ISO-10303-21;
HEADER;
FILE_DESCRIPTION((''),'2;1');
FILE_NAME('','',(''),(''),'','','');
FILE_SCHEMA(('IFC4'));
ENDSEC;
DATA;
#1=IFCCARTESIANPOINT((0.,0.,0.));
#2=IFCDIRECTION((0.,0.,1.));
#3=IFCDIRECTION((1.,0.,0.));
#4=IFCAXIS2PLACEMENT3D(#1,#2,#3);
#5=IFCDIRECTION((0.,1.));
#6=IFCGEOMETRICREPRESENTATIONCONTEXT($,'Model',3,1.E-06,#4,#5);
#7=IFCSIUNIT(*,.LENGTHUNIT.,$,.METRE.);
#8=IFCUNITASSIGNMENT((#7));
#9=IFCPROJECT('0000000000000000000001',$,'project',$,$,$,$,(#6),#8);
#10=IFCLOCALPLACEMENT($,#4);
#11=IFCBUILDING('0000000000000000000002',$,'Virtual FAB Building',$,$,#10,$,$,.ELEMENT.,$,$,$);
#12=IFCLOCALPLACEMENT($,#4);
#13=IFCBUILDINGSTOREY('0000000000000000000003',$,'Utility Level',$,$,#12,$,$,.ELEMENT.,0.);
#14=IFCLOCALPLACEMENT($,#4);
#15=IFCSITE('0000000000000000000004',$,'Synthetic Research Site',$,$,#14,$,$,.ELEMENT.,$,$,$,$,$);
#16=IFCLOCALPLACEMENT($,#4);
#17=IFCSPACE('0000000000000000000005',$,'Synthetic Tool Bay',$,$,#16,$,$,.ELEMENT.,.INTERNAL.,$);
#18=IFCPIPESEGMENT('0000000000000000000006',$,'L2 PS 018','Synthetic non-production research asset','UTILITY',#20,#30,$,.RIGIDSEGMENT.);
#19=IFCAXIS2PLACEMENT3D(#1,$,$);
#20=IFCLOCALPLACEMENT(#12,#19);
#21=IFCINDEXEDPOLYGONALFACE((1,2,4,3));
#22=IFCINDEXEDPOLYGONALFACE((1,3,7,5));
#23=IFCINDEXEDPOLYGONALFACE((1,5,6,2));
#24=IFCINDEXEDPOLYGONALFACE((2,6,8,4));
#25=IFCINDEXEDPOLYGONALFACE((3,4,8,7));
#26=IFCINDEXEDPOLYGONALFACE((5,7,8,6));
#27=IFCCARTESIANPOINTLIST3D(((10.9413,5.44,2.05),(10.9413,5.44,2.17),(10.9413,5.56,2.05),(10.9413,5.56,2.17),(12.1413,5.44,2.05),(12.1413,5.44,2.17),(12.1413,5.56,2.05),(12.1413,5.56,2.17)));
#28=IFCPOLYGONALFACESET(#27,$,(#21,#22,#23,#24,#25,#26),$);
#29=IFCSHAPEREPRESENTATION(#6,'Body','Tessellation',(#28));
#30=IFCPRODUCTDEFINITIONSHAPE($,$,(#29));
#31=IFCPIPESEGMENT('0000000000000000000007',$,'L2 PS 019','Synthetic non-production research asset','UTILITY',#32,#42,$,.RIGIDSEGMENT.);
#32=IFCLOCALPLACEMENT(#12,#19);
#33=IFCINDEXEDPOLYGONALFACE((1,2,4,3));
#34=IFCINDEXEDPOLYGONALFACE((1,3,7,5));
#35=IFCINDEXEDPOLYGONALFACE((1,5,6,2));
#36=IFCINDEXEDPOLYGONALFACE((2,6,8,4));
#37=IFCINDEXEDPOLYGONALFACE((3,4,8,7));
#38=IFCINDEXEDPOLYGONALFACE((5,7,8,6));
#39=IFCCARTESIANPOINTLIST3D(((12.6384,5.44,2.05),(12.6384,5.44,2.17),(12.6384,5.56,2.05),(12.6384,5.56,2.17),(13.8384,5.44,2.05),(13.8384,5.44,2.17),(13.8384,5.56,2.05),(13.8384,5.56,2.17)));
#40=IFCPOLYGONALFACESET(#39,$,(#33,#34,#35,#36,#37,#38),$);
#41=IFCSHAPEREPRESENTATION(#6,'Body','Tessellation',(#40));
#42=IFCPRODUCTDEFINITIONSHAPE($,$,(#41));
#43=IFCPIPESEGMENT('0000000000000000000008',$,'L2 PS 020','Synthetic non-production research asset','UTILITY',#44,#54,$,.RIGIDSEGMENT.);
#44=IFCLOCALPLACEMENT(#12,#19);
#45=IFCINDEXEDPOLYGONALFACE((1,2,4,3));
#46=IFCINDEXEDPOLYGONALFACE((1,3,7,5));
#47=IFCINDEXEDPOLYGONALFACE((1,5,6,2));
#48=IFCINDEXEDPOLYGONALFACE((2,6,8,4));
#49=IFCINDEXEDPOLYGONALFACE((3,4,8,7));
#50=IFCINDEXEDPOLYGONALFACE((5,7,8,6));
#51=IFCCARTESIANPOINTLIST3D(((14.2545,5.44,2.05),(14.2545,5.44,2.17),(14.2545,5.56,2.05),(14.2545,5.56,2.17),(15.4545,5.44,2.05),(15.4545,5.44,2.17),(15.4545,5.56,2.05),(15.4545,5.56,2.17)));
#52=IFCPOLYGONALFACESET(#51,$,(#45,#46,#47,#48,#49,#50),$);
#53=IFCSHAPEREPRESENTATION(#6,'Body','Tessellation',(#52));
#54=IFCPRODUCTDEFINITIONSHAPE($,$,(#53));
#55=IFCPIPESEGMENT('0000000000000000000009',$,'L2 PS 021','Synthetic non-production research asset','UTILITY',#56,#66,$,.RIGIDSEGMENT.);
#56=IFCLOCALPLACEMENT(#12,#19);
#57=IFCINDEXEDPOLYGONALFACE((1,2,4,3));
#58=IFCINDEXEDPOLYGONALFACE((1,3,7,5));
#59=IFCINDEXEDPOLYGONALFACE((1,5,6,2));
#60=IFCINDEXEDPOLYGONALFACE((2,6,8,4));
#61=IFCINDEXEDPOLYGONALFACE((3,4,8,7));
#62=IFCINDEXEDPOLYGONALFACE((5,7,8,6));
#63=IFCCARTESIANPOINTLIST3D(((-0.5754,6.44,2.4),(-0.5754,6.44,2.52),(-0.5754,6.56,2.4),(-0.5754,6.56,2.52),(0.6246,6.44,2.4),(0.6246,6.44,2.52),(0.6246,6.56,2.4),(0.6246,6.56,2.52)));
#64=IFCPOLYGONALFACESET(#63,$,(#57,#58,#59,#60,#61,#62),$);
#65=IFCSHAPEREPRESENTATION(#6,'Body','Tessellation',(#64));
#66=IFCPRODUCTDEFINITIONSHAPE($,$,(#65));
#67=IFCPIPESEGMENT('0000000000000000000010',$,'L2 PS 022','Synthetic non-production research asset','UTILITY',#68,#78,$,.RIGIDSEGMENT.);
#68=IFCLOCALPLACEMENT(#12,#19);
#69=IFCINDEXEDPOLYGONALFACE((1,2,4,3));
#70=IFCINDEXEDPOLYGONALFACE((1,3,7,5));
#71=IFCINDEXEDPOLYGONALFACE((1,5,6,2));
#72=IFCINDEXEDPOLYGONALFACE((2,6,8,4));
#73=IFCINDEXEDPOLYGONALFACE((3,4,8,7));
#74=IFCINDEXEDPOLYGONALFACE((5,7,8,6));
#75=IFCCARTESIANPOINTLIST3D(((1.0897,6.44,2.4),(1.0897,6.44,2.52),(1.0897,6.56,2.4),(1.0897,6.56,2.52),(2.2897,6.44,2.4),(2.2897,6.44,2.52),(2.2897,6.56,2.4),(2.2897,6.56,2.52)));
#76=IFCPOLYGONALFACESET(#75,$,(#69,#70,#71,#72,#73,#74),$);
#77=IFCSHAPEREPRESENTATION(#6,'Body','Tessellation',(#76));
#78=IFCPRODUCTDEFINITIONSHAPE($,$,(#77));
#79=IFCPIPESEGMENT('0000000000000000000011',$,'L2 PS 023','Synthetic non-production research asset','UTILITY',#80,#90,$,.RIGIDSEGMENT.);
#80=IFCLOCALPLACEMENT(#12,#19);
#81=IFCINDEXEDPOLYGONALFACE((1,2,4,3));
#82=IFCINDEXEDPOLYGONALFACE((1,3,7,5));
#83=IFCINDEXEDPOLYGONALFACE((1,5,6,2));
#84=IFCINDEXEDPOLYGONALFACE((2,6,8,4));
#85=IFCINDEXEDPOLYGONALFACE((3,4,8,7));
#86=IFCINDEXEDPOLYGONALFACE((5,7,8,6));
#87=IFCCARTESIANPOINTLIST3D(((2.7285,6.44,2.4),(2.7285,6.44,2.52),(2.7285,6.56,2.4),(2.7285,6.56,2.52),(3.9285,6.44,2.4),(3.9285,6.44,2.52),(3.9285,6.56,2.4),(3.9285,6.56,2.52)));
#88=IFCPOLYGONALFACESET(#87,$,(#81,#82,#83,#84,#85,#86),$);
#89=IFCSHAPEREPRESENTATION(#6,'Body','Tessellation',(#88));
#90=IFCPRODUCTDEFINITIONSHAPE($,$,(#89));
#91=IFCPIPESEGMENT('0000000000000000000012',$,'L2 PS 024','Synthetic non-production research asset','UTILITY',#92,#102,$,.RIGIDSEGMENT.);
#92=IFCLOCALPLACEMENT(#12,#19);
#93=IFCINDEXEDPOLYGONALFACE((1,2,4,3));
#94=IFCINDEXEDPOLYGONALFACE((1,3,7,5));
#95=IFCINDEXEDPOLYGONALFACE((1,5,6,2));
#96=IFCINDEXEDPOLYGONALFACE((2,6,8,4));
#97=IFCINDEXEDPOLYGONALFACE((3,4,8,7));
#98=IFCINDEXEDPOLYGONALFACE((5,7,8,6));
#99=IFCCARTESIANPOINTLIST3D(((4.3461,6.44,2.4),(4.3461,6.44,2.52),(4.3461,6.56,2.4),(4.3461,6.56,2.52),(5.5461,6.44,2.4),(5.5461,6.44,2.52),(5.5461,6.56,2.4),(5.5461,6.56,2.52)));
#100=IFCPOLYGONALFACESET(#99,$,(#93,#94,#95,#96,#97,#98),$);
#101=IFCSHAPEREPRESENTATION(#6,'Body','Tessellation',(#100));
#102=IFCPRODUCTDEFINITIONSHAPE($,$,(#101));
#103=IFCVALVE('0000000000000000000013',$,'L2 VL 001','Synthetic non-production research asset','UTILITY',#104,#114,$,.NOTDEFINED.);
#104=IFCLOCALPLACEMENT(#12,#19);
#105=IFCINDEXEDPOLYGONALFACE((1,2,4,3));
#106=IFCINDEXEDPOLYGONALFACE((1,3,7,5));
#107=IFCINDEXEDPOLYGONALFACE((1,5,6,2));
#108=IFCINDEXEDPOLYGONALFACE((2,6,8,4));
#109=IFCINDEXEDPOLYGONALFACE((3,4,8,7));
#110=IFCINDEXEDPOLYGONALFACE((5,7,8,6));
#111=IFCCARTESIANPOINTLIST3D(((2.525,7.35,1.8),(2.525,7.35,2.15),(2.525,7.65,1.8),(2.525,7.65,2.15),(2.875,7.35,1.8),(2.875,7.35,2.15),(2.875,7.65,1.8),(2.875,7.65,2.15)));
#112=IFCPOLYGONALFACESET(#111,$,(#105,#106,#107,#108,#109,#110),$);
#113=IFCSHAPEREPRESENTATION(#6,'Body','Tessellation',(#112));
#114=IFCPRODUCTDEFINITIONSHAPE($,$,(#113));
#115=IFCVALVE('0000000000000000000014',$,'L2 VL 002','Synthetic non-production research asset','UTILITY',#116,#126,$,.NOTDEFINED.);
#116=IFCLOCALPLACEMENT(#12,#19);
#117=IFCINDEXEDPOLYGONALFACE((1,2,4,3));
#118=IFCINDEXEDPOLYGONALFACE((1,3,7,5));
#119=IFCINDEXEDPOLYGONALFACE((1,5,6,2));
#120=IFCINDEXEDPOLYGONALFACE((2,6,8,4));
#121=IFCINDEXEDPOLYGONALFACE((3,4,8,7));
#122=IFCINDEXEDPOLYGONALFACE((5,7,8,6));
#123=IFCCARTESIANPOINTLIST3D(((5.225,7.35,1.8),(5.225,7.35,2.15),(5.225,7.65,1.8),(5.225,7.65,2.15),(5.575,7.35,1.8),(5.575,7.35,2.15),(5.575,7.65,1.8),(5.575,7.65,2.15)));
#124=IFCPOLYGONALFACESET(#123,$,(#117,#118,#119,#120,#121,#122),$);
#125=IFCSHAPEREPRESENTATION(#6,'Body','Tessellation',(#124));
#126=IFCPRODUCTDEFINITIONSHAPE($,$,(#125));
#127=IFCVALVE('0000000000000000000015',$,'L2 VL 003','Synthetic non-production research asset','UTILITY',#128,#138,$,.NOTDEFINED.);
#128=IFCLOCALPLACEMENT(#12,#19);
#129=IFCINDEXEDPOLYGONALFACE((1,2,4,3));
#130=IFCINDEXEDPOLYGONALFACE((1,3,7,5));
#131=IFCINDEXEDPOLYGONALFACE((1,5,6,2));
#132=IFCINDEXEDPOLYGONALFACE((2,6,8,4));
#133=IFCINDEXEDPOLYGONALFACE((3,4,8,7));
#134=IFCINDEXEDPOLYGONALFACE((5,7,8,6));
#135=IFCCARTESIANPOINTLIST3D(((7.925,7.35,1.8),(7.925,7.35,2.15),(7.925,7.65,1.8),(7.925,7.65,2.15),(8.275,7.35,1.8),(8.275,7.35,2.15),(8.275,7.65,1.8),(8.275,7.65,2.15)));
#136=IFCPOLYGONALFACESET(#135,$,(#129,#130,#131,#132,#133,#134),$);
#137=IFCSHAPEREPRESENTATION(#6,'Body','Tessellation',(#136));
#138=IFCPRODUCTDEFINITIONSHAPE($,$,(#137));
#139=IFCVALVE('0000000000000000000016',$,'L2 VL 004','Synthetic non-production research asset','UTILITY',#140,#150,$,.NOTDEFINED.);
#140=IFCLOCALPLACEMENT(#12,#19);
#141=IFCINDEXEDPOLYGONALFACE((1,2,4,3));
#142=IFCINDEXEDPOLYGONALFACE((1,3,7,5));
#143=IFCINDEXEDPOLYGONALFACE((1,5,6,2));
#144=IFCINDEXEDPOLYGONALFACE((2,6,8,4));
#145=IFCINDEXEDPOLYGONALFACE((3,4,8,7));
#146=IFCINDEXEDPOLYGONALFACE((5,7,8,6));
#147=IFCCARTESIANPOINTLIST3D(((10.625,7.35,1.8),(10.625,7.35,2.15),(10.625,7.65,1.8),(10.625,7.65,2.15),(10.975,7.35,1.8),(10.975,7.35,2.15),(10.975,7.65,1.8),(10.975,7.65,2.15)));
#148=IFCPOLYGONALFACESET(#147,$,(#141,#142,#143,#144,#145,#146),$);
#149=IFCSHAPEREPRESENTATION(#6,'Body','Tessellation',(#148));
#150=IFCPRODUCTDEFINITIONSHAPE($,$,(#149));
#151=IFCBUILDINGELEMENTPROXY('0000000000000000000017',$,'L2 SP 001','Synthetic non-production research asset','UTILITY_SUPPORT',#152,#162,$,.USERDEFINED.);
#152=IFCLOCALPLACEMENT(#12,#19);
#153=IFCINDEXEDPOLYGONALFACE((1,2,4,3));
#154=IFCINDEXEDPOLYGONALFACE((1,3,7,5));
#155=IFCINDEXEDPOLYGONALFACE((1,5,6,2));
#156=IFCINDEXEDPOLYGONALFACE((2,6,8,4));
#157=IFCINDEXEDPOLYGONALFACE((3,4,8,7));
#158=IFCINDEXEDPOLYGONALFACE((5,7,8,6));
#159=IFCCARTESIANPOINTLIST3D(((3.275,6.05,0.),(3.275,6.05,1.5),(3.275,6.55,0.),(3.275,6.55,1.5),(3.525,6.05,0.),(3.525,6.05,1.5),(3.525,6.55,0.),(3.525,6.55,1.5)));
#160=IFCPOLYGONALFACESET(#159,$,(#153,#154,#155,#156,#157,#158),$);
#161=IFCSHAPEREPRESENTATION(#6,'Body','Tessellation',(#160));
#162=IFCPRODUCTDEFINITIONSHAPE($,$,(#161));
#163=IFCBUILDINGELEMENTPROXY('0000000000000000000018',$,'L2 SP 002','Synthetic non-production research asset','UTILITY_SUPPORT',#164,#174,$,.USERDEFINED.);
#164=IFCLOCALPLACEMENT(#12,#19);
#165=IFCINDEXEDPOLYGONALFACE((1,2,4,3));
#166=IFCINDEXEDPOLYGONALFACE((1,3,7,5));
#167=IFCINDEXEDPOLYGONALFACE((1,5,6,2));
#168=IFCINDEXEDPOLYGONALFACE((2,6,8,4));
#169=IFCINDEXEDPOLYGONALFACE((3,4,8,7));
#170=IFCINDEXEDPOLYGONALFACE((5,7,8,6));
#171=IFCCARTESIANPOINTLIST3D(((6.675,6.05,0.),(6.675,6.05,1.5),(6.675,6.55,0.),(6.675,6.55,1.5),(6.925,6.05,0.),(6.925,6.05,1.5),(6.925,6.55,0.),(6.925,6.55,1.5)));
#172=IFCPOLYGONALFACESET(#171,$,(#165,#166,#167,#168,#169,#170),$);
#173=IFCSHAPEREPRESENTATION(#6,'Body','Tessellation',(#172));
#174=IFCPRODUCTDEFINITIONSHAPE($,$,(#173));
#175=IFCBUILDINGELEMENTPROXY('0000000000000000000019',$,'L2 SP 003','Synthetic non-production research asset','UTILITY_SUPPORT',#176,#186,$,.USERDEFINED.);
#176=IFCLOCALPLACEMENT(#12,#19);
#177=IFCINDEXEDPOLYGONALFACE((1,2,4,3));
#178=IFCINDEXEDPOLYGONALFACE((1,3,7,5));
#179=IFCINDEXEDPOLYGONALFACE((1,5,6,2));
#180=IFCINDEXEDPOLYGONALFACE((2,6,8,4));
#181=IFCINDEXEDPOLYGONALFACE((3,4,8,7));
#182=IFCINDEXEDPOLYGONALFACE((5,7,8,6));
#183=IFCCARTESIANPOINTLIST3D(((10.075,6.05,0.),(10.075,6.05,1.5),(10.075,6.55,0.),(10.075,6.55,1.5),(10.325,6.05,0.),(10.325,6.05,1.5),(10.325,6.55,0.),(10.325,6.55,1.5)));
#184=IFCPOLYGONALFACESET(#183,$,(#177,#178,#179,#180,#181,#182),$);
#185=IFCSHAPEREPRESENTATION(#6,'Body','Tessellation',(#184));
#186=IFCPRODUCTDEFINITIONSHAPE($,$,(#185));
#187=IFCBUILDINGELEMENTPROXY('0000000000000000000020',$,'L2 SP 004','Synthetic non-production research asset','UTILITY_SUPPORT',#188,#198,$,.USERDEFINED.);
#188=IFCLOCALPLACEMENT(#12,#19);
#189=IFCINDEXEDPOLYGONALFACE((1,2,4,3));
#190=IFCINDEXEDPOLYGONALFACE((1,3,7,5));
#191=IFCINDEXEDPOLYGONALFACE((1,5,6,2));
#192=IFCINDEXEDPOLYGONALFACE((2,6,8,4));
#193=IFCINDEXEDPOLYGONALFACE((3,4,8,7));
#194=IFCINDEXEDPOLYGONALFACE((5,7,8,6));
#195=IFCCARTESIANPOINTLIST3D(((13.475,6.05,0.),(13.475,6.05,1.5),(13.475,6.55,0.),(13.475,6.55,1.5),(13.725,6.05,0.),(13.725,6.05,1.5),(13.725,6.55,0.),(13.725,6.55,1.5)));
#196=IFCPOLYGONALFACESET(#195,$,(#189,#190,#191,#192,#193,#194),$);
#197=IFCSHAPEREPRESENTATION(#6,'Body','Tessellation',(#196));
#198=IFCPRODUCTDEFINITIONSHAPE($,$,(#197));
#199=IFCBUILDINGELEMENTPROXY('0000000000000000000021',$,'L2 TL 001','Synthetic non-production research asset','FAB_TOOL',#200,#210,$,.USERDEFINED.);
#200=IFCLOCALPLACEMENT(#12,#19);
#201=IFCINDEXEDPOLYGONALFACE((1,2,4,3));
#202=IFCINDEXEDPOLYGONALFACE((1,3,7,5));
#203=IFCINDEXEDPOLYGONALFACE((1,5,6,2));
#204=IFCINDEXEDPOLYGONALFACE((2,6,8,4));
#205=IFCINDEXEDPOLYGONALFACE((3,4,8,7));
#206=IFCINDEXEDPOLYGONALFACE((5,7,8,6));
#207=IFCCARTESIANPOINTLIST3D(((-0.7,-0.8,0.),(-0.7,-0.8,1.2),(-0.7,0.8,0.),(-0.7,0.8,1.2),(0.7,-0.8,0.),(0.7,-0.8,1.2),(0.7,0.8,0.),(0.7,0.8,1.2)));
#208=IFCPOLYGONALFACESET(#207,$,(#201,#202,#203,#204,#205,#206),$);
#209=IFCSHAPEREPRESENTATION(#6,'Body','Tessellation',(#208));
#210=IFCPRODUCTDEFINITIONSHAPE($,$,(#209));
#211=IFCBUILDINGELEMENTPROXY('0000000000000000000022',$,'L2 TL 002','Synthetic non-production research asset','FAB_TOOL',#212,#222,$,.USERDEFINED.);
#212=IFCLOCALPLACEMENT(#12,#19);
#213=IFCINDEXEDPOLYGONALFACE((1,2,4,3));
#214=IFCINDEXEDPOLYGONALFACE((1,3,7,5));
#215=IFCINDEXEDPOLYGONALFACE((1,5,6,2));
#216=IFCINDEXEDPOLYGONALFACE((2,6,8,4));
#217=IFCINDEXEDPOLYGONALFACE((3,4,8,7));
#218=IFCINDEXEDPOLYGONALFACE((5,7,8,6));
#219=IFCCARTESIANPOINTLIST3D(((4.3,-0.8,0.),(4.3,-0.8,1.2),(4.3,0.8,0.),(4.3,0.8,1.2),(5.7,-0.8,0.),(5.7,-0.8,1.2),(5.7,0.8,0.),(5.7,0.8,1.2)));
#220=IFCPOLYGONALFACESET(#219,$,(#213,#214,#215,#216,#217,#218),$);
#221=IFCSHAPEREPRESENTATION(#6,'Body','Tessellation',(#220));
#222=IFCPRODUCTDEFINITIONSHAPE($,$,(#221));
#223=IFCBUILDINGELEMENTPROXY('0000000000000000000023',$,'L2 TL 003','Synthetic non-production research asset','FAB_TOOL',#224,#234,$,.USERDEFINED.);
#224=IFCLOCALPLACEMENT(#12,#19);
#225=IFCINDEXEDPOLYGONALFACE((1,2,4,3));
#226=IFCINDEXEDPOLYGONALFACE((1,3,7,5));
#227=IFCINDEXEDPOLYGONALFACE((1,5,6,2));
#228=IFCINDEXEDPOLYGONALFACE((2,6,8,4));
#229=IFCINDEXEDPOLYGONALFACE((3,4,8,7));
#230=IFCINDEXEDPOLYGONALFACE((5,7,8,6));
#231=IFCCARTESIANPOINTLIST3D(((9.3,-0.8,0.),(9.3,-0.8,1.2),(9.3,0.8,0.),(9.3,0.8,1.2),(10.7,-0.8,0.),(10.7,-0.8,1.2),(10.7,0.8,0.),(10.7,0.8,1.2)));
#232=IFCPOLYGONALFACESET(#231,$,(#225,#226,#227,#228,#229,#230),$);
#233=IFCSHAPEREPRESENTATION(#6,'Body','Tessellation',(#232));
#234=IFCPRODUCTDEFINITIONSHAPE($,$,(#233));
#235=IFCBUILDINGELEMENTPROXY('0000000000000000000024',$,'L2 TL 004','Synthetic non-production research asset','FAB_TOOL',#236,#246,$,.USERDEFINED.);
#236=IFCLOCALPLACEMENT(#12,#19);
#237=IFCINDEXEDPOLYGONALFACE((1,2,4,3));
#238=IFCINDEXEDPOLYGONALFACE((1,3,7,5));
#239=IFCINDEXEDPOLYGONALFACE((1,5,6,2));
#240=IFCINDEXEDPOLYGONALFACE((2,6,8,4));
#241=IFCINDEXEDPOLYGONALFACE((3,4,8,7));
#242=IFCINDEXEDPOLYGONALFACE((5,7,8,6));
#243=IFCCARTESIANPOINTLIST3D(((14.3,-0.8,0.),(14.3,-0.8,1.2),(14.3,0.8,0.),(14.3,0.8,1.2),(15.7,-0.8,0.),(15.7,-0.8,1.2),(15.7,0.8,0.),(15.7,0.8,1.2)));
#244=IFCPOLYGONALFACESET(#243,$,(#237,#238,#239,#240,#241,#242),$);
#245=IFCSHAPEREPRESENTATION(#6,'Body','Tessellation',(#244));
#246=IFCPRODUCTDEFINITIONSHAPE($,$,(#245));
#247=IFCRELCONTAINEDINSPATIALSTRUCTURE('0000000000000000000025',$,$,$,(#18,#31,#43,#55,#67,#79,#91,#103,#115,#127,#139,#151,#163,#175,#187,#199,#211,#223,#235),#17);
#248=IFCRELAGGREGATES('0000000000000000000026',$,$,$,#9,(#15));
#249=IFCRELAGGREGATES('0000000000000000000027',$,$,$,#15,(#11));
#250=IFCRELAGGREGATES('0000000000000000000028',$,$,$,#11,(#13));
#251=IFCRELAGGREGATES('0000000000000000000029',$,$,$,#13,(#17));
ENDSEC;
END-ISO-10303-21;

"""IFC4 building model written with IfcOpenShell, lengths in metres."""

from ifc_helpers import new_model, si_unit, direction, frame, origin_with_axes, origin_2d_with_axis, place, context, project, spatial, rectangle, extrude, element, save


model = new_model("IFC4")

# Units and contexts
model_context = context("Model", 3, precision=1e-06, world=origin_with_axes(), true_north=direction((0.0, 1.0)))
ifc_project = project(units=[si_unit("LENGTHUNIT", "METRE")], contexts=[model_context])

# Site, building, storey, space
site_placement = place(None, origin_with_axes())
site = spatial("IfcSite", under=ifc_project, at=site_placement, Name="Synthetic Research Site", CompositionType="ELEMENT")
building_placement = place(None, origin_with_axes())
building = spatial("IfcBuilding", under=site, at=building_placement, Name="Virtual FAB Building", CompositionType="ELEMENT")
storey_placement = place(None, origin_with_axes())
storey = spatial("IfcBuildingStorey", under=building, at=storey_placement, Name="Utility Level", CompositionType="ELEMENT", Elevation=0.0)
space_placement = place(None, origin_with_axes())
space = spatial("IfcSpace", under=storey, at=space_placement, Name="Synthetic Tool Bay", CompositionType="ELEMENT", PredefinedType="INTERNAL")

# Pipe segments
for number, where, z_axis, x_axis, name in (
    (1, (11.5413, 5.5, 2.05), (0.0, 0.0, 1.0), (1.0, 0.0, 0.0), "L2 PS 018"),
    (2, (13.2384, 5.5, 2.05), (0.0, 0.0, 1.0), (1.0, 0.0, 0.0), "L2 PS 019"),
    (3, (14.8545, 5.5, 2.05), (0.0, 0.0, 1.0), (1.0, 0.0, 0.0), "L2 PS 020"),
    (4, (0.0246, 6.5, 2.4), (0.0, 0.0, 1.0), (1.0, 0.0, 0.0), "L2 PS 021"),
    (5, (1.6897, 6.5, 2.4), (0.0, 0.0, 1.0), (1.0, 0.0, 0.0), "L2 PS 022"),
    (6, (3.3285, 6.5, 2.4), (0.0, 0.0, 1.0), (1.0, 0.0, 0.0), "L2 PS 023"),
    (7, (4.9461, 6.5, 2.4), (0.0, 0.0, 1.0), (1.0, 0.0, 0.0), "L2 PS 024"),
):
    element("IfcPipeSegment", number, at=place(None, frame(where, z_axis=z_axis, x_axis=x_axis)), inside=space, Name=name, Description="Synthetic non-production research asset", ObjectType="UTILITY", PredefinedType="RIGIDSEGMENT", context=model_context, shape_type="SweptSolid", body=[
        extrude(rectangle(XDim=1.2, YDim=0.12, at=origin_2d_with_axis()), origin_with_axes(), (0.0, 0.0, 1.0), 0.12),
    ])

# Valves
for number, where, z_axis, x_axis, name in (
    (8, (2.7, 7.5, 1.8), (0.0, 0.0, 1.0), (1.0, 0.0, 0.0), "L2 VL 001"),
    (9, (5.4, 7.5, 1.8), (0.0, 0.0, 1.0), (1.0, 0.0, 0.0), "L2 VL 002"),
    (10, (8.1, 7.5, 1.8), (0.0, 0.0, 1.0), (1.0, 0.0, 0.0), "L2 VL 003"),
    (11, (10.8, 7.5, 1.8), (0.0, 0.0, 1.0), (1.0, 0.0, 0.0), "L2 VL 004"),
):
    element("IfcValve", number, at=place(None, frame(where, z_axis=z_axis, x_axis=x_axis)), inside=space, Name=name, Description="Synthetic non-production research asset", ObjectType="UTILITY", PredefinedType="NOTDEFINED", context=model_context, shape_type="SweptSolid", body=[
        extrude(rectangle(XDim=0.35, YDim=0.3, at=origin_2d_with_axis()), origin_with_axes(), (0.0, 0.0, 1.0), 0.35),
    ])

# Building element proxies
for number, where, z_axis, x_axis, name in (
    (12, (3.4, 6.3, 0.0), (0.0, 0.0, 1.0), (1.0, 0.0, 0.0), "L2 SP 001"),
    (13, (6.8, 6.3, 0.0), (0.0, 0.0, 1.0), (1.0, 0.0, 0.0), "L2 SP 002"),
    (14, (10.2, 6.3, 0.0), (0.0, 0.0, 1.0), (1.0, 0.0, 0.0), "L2 SP 003"),
    (15, (13.6, 6.3, 0.0), (0.0, 0.0, 1.0), (1.0, 0.0, 0.0), "L2 SP 004"),
):
    element("IfcBuildingElementProxy", number, at=place(None, frame(where, z_axis=z_axis, x_axis=x_axis)), inside=space, Name=name, Description="Synthetic non-production research asset", ObjectType="UTILITY_SUPPORT", PredefinedType="USERDEFINED", context=model_context, shape_type="SweptSolid", body=[
        extrude(rectangle(XDim=0.25, YDim=0.5, at=origin_2d_with_axis()), origin_with_axes(), (0.0, 0.0, 1.0), 1.5),
    ])
for number, where, z_axis, x_axis, name in (
    (16, (0.0, 0.0, 0.0), (0.0, 0.0, 1.0), (1.0, 0.0, 0.0), "L2 TL 001"),
    (17, (5.0, 0.0, 0.0), (0.0, 0.0, 1.0), (1.0, 0.0, 0.0), "L2 TL 002"),
    (18, (10.0, 0.0, 0.0), (0.0, 0.0, 1.0), (1.0, 0.0, 0.0), "L2 TL 003"),
    (19, (15.0, 0.0, 0.0), (0.0, 0.0, 1.0), (1.0, 0.0, 0.0), "L2 TL 004"),
):
    element("IfcBuildingElementProxy", number, at=place(None, frame(where, z_axis=z_axis, x_axis=x_axis)), inside=space, Name=name, Description="Synthetic non-production research asset", ObjectType="FAB_TOOL", PredefinedType="USERDEFINED", context=model_context, shape_type="SweptSolid", body=[
        extrude(rectangle(XDim=1.4, YDim=1.6, at=origin_2d_with_axis()), origin_with_axes(), (0.0, 0.0, 1.0), 1.2),
    ])

save(model, "model.ifc")
